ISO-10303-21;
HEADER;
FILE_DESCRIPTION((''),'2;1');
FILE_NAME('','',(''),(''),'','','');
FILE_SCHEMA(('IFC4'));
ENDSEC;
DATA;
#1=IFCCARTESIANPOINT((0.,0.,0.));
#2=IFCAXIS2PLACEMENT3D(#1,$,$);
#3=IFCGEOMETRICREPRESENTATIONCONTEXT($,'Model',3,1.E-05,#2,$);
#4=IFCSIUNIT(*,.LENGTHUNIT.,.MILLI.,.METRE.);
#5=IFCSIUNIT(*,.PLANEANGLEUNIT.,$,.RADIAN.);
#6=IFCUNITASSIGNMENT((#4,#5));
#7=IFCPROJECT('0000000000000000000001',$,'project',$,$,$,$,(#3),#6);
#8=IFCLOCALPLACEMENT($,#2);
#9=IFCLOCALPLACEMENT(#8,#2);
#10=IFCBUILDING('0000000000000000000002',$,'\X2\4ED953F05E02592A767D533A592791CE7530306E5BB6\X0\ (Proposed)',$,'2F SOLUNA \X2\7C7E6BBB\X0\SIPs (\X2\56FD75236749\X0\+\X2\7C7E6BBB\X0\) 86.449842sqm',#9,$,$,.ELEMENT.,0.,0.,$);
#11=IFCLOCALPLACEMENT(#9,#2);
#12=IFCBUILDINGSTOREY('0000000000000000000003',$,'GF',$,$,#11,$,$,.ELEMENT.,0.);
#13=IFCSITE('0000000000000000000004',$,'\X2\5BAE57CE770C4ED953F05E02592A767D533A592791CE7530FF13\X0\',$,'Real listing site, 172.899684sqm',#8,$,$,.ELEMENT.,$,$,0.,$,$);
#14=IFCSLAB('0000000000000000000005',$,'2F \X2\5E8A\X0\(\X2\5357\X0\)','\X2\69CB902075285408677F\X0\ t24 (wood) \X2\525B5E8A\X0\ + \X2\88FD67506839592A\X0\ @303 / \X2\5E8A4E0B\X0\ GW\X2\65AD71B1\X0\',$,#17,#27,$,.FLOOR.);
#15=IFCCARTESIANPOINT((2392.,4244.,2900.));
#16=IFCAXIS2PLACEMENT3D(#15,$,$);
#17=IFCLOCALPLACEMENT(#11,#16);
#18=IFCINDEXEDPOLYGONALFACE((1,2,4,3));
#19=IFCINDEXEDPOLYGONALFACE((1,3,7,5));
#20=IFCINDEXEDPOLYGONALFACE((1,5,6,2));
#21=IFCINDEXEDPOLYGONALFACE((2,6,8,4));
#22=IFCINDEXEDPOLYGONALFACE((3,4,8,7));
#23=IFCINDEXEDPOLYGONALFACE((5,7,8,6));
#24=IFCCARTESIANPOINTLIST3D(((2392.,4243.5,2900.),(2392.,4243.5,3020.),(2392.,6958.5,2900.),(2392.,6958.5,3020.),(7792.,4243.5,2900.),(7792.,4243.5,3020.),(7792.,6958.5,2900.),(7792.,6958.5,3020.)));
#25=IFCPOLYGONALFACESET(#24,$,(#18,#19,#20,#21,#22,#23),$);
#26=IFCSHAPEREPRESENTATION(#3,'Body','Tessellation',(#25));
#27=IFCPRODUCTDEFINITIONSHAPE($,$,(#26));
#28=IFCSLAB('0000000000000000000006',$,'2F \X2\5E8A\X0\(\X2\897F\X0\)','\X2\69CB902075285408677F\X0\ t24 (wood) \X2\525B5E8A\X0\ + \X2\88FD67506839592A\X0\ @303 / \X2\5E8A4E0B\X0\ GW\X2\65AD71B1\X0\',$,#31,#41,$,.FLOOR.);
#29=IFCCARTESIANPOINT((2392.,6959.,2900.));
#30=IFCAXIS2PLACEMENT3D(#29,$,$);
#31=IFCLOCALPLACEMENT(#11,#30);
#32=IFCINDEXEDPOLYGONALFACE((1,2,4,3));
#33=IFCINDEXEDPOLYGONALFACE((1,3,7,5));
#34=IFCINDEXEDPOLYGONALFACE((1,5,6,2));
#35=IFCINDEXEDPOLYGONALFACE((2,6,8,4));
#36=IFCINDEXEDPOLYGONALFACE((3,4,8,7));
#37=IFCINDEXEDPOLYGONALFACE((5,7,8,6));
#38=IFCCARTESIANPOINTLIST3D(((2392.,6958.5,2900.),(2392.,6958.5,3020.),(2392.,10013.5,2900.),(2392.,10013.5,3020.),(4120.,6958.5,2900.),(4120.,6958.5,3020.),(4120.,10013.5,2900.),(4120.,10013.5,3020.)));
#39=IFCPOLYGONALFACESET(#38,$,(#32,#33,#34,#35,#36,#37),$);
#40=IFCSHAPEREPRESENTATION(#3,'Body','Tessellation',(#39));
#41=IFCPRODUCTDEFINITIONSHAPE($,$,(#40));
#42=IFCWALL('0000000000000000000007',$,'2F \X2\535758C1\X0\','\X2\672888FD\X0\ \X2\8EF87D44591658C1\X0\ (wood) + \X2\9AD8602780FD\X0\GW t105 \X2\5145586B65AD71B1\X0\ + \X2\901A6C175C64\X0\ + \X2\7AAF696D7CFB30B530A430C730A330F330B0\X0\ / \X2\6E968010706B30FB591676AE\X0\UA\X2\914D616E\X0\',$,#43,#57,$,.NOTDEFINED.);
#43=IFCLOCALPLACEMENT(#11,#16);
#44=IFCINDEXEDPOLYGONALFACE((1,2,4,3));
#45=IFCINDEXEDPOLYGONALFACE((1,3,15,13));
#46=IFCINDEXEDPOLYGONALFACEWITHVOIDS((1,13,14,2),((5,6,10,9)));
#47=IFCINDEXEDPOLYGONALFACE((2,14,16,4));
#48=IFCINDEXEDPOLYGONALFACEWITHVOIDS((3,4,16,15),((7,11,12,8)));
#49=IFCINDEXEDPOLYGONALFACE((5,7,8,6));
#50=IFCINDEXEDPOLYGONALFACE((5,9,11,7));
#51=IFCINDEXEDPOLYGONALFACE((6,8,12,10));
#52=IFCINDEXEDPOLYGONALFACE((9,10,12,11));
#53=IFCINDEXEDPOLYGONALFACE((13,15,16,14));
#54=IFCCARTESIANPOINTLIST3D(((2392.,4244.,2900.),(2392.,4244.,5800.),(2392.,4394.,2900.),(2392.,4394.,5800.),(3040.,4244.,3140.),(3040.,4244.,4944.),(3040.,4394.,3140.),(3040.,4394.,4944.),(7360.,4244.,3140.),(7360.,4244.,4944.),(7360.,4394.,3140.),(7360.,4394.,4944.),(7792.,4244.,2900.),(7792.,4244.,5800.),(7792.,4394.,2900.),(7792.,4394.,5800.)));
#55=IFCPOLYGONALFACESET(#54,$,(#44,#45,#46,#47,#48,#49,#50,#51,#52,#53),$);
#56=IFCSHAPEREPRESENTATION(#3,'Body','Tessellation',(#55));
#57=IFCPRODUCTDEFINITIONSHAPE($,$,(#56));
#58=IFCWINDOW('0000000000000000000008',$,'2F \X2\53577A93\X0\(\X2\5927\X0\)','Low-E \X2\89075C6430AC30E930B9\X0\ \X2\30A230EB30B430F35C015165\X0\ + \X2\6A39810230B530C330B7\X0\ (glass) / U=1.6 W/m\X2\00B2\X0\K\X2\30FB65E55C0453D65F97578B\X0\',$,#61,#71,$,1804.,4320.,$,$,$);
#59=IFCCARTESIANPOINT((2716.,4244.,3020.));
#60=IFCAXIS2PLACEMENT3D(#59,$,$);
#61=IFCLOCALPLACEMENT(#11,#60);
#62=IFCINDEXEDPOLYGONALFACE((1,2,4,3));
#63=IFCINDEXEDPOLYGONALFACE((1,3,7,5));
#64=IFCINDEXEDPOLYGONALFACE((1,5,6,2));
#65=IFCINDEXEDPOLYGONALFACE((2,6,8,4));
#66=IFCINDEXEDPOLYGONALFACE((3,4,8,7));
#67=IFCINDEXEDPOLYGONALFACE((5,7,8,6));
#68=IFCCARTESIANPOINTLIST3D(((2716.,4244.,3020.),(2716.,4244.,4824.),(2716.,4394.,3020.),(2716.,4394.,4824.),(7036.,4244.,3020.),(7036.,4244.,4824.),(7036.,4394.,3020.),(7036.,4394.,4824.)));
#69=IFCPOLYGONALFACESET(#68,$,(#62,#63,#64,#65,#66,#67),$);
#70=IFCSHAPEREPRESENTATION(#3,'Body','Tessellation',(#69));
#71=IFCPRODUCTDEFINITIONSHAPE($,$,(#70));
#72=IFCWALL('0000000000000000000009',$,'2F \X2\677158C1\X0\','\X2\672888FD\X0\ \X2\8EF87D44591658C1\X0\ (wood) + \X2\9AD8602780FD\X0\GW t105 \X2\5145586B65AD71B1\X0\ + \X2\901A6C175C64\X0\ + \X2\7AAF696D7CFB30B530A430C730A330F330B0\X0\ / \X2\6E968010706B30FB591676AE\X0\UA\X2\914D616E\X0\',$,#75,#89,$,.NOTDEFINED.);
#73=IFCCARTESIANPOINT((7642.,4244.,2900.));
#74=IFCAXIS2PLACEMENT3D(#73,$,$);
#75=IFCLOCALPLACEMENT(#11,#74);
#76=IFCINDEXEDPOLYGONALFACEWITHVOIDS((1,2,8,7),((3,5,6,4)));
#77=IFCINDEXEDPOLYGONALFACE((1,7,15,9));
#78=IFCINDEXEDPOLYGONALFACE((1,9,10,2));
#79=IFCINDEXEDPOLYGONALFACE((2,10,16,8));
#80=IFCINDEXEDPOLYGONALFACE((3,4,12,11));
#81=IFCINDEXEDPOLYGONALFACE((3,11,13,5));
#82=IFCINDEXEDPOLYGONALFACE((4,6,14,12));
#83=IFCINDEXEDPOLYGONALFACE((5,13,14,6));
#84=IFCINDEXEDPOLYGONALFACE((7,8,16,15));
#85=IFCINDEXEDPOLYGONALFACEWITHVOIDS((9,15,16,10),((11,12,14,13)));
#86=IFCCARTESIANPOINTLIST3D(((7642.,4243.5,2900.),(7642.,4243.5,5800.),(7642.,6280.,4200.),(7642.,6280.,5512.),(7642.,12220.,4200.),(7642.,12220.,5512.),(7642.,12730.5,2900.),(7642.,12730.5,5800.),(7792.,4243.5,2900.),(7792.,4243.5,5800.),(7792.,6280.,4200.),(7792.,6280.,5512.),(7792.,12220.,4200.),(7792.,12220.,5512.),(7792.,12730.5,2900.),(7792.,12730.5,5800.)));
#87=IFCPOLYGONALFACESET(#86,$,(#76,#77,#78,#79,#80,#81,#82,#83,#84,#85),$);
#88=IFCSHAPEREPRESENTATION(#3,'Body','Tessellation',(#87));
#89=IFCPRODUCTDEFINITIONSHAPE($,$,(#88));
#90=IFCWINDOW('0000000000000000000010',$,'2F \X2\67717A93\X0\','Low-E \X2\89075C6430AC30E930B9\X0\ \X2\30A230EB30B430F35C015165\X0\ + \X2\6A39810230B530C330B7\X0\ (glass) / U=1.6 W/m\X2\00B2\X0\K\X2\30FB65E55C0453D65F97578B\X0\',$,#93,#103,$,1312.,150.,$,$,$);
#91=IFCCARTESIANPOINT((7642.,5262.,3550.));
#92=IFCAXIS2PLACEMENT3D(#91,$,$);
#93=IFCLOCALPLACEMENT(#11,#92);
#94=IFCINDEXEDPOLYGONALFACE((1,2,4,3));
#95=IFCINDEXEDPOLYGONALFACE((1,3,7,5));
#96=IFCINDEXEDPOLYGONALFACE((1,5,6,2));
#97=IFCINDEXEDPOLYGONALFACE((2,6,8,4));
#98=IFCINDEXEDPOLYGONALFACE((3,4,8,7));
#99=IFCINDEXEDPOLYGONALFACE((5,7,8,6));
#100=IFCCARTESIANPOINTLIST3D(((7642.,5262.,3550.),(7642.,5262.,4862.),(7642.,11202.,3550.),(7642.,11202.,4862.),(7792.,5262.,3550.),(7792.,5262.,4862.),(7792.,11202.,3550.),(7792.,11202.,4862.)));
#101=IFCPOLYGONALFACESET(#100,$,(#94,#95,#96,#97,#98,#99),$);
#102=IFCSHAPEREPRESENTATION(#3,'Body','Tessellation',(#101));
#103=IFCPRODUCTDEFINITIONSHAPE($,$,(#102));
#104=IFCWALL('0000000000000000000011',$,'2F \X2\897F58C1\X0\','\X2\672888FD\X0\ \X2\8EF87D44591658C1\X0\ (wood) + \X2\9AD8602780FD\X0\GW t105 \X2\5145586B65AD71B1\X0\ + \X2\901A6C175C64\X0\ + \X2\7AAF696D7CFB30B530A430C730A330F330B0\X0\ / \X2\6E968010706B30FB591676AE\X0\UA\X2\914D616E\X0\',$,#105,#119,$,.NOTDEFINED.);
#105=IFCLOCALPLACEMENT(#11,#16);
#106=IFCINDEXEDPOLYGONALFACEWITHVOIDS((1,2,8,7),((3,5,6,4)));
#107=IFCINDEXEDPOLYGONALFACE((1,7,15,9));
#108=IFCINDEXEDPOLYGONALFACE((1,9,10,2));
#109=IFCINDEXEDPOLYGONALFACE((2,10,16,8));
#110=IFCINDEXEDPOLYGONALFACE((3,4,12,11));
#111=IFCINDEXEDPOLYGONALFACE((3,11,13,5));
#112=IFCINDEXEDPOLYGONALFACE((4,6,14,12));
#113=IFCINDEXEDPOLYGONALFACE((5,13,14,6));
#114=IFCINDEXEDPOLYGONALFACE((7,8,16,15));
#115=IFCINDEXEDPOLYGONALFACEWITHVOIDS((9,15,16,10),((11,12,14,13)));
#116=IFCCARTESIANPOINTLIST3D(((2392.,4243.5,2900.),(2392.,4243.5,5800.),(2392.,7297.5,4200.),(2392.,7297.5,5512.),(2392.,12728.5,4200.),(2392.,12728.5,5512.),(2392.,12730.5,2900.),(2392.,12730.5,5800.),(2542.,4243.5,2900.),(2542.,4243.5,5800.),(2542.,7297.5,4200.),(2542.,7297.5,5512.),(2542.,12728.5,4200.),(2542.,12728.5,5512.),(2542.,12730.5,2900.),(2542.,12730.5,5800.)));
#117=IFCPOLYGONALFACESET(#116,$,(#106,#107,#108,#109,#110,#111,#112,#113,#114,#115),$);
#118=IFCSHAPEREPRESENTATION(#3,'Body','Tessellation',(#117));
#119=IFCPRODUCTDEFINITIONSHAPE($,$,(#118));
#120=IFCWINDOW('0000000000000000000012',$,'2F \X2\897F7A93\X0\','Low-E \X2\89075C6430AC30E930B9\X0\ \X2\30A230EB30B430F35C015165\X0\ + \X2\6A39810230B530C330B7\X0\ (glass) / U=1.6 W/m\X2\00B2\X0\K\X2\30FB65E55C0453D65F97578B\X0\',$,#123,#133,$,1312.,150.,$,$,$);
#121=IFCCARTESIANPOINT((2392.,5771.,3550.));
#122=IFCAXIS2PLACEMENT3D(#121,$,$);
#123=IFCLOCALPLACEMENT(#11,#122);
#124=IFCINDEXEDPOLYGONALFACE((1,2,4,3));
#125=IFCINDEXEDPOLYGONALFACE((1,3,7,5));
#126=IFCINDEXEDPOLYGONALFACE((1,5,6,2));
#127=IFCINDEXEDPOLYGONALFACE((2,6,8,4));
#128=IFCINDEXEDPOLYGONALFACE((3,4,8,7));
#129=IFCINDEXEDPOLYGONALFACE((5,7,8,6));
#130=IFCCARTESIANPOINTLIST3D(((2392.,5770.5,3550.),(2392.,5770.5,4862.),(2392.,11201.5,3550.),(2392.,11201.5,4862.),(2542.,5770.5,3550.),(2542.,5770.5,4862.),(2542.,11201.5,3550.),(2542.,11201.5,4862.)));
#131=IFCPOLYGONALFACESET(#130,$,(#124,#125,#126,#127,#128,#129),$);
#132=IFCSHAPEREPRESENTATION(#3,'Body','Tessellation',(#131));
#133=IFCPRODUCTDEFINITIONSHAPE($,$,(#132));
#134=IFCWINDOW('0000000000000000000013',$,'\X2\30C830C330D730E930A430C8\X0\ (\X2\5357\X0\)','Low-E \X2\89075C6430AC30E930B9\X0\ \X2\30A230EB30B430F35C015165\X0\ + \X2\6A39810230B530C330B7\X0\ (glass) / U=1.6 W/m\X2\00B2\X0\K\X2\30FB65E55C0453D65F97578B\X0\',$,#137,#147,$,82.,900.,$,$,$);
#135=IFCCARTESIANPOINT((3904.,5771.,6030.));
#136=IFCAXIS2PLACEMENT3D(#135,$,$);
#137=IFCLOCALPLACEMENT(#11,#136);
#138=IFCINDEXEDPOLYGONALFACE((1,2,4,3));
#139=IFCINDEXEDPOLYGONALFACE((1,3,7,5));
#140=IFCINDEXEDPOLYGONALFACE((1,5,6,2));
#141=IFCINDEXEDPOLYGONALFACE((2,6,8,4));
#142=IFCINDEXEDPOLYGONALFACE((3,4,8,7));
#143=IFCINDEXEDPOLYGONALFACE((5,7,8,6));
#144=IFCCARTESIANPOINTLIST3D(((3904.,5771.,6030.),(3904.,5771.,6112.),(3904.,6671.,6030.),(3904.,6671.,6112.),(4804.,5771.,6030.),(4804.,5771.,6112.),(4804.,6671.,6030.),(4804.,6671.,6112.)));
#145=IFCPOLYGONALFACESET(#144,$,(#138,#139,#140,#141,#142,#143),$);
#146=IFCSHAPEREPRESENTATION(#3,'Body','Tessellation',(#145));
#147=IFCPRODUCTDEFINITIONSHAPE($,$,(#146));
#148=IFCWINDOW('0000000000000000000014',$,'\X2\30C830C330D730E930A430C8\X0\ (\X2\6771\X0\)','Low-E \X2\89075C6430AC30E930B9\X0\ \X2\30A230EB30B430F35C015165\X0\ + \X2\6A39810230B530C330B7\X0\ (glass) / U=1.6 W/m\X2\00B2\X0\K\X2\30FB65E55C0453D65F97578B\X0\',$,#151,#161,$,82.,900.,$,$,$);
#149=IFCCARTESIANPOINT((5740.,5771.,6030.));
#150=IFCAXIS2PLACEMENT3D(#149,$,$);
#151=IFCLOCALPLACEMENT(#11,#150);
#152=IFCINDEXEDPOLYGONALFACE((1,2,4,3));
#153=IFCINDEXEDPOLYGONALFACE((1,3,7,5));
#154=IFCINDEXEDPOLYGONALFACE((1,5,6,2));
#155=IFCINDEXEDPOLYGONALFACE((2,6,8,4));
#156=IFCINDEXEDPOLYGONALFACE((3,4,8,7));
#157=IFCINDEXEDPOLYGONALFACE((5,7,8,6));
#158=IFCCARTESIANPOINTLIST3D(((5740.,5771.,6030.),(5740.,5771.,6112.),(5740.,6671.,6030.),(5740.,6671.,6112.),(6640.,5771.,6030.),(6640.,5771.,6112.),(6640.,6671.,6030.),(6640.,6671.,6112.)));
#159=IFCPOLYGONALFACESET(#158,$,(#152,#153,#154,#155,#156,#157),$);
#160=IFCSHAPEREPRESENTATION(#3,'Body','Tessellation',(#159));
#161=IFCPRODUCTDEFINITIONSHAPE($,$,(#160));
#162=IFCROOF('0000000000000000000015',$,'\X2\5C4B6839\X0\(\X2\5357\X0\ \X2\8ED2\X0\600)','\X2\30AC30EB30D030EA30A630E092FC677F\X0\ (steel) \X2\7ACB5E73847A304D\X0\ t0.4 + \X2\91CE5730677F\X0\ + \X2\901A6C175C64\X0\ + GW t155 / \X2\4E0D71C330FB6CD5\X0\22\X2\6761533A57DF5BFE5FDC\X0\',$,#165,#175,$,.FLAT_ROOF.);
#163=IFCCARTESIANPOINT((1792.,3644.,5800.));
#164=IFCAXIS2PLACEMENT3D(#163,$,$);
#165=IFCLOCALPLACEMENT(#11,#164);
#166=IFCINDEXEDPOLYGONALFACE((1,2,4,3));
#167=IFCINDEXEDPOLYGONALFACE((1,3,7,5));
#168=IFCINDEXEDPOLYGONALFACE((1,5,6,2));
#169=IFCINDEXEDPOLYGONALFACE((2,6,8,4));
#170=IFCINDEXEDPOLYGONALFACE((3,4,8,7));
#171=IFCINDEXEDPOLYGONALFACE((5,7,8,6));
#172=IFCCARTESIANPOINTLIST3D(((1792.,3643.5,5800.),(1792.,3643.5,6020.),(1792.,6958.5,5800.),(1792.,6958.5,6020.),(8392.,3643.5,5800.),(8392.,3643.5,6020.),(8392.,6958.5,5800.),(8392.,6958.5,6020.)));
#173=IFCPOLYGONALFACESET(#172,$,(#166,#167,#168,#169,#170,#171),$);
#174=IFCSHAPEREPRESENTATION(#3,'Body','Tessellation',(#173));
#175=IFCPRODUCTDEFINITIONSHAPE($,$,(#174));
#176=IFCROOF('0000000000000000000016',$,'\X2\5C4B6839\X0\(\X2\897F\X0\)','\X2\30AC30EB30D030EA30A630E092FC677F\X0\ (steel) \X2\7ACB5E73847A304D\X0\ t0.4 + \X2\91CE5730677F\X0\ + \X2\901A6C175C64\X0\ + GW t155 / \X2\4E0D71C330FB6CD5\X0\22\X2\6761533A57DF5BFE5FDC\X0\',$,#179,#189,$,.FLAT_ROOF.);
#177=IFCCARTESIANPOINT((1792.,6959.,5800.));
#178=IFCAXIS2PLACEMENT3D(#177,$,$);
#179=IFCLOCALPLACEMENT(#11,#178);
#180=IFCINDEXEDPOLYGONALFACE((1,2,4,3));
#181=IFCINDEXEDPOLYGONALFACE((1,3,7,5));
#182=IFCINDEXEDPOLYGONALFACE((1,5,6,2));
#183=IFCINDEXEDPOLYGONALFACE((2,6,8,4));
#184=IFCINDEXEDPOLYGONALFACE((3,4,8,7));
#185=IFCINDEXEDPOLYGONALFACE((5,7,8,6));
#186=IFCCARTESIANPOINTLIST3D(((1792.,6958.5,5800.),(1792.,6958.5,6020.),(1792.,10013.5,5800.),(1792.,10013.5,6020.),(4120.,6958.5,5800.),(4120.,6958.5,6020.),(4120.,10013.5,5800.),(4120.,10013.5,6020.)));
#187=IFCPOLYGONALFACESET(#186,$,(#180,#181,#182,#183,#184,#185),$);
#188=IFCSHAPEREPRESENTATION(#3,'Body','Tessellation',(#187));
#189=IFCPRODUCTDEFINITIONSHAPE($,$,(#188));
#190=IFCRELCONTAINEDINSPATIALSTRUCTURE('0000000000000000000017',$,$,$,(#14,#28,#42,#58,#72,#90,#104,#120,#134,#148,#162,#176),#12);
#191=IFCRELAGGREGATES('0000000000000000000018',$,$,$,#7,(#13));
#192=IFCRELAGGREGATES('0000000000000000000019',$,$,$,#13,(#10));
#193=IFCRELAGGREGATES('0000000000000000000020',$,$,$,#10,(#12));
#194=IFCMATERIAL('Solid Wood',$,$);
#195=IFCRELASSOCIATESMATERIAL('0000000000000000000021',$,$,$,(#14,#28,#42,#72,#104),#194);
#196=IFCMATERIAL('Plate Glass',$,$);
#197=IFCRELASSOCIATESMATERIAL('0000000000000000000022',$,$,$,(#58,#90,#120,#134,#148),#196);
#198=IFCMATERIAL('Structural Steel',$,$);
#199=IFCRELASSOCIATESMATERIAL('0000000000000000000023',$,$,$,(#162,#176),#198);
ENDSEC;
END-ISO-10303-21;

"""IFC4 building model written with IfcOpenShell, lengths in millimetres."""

from ifc_helpers import new_model, si_unit, frame, frame_2d, origin, place, context, project, spatial, rectangle, extrude, material, element, fill, save


model = new_model("IFC4")

# Units and contexts
model_context = context("Model", 3, precision=1e-05, world=origin())
ifc_project = project(units=[si_unit("LENGTHUNIT", "METRE", prefix="MILLI"), si_unit("PLANEANGLEUNIT", "RADIAN")], contexts=[model_context])

# Site, building, storey
site_placement = place(None, origin())
site = spatial("IfcSite", under=ifc_project, at=site_placement, Name="宮城県仙台市太白区大野田３", ObjectType="Real listing site, 172.899684sqm", CompositionType="ELEMENT", RefElevation=0.0)
building_placement = place(site_placement, origin())
building = spatial("IfcBuilding", under=site, at=building_placement, Name="仙台市太白区大野田の家 (Proposed)", ObjectType="2F SOLUNA 籾殻SIPs (国産杉+籾殻) 86.449842sqm", CompositionType="ELEMENT", ElevationOfRefHeight=0.0, ElevationOfTerrain=0.0)
storey_placement = place(building_placement, origin())
storey = spatial("IfcBuildingStorey", under=building, at=storey_placement, Name="GF", CompositionType="ELEMENT", Elevation=0.0)

# Slabs
ifc_material_1 = material(Name="Solid Wood")
slab_1_placement = place(storey_placement, frame((2392.0, 4244.0, 2900.0)))
element("IfcSlab", 1, at=slab_1_placement, inside=storey, material=ifc_material_1, Name="2F 床(南)", Description="構造用合板 t24 (wood) 剛床 + 製材根太 @303 / 床下 GW断熱", PredefinedType="FLOOR", context=model_context, shape_type="SweptSolid", body=[
    extrude(rectangle(XDim=5400.0, YDim=2715.0, at=frame_2d((2700.0, 1357.0))), frame((2392.0, 4244.0, 2900.0)), (0.0, 0.0, 1.0), 120.0),
])
slab_2_placement = place(storey_placement, frame((2392.0, 6959.0, 2900.0)))
element("IfcSlab", 2, at=slab_2_placement, inside=storey, material=ifc_material_1, Name="2F 床(西)", Description="構造用合板 t24 (wood) 剛床 + 製材根太 @303 / 床下 GW断熱", PredefinedType="FLOOR", context=model_context, shape_type="SweptSolid", body=[
    extrude(rectangle(XDim=1728.0, YDim=3055.0, at=frame_2d((864.0, 1527.0))), frame((2392.0, 6959.0, 2900.0)), (0.0, 0.0, 1.0), 120.0),
])

# Walls, openings, windows
wall_1_placement = place(storey_placement, frame((2392.0, 4244.0, 2900.0)))
wall_1 = element("IfcWall", 3, at=wall_1_placement, inside=storey, material=ifc_material_1, Name="2F 南壁", Description="木製 軸組外壁 (wood) + 高性能GW t105 充填断熱 + 通気層 + 窯業系サイディング / 準耐火・外皮UA配慮", PredefinedType="NOTDEFINED", context=model_context, shape_type="SweptSolid", body=[
    extrude(rectangle(XDim=5400.0, YDim=150.0, at=frame_2d((2700.0, 75.0))), frame((2392.0, 4244.0, 2900.0)), (0.0, 0.0, 1.0), 2900.0),
])
opening_1_placement = place(storey_placement, frame((2716.0, 4244.0, 3020.0)))
opening_1 = element("IfcOpeningElement", 4, at=opening_1_placement, cuts=wall_1, PredefinedType="NOTDEFINED", context=model_context, shape_type="SweptSolid", body=[
    extrude(rectangle(XDim=4320.0, YDim=150.0, at=frame_2d((2160.0, 75.0))), frame((2716.0, 4244.0, 3020.0)), (0.0, 0.0, 1.0), 1804.0),
])
ifc_material_2 = material(Name="Plate Glass")
window_1_placement = place(storey_placement, frame((2716.0, 4244.0, 3020.0)))
window_1 = element("IfcWindow", 5, at=window_1_placement, inside=storey, material=ifc_material_2, Name="2F 南窓(大)", Description="Low-E 複層ガラス アルゴン封入 + 樹脂サッシ (glass) / U=1.6 W/m²K・日射取得型", OverallHeight=1804.0, OverallWidth=4320.0, context=model_context, shape_type="SweptSolid", body=[
    extrude(rectangle(XDim=4320.0, YDim=150.0, at=frame_2d((2160.0, 75.0))), frame((2716.0, 4244.0, 3020.0)), (0.0, 0.0, 1.0), 1804.0),
])
fill(opening_1, window_1)
wall_2_placement = place(storey_placement, frame((7642.0, 4244.0, 2900.0)))
wall_2 = element("IfcWall", 6, at=wall_2_placement, inside=storey, material=ifc_material_1, Name="2F 東壁", Description="木製 軸組外壁 (wood) + 高性能GW t105 充填断熱 + 通気層 + 窯業系サイディング / 準耐火・外皮UA配慮", PredefinedType="NOTDEFINED", context=model_context, shape_type="SweptSolid", body=[
    extrude(rectangle(XDim=150.0, YDim=8487.0, at=frame_2d((75.0, 4243.0))), frame((7642.0, 4244.0, 2900.0)), (0.0, 0.0, 1.0), 2900.0),
])
opening_2_placement = place(storey_placement, frame((7642.0, 5262.0, 3550.0)))
opening_2 = element("IfcOpeningElement", 7, at=opening_2_placement, cuts=wall_2, PredefinedType="NOTDEFINED", context=model_context, shape_type="SweptSolid", body=[
    extrude(rectangle(XDim=150.0, YDim=5940.0, at=frame_2d((75.0, 2970.0))), frame((7642.0, 5262.0, 3550.0)), (0.0, 0.0, 1.0), 1312.0),
])
window_2_placement = place(storey_placement, frame((7642.0, 5262.0, 3550.0)))
window_2 = element("IfcWindow", 8, at=window_2_placement, inside=storey, material=ifc_material_2, Name="2F 東窓", Description="Low-E 複層ガラス アルゴン封入 + 樹脂サッシ (glass) / U=1.6 W/m²K・日射取得型", OverallHeight=1312.0, OverallWidth=150.0, context=model_context, shape_type="SweptSolid", body=[
    extrude(rectangle(XDim=150.0, YDim=5940.0, at=frame_2d((75.0, 2970.0))), frame((7642.0, 5262.0, 3550.0)), (0.0, 0.0, 1.0), 1312.0),
])
fill(opening_2, window_2)
wall_3_placement = place(storey_placement, frame((2392.0, 4244.0, 2900.0)))
wall_3 = element("IfcWall", 9, at=wall_3_placement, inside=storey, material=ifc_material_1, Name="2F 西壁", Description="木製 軸組外壁 (wood) + 高性能GW t105 充填断熱 + 通気層 + 窯業系サイディング / 準耐火・外皮UA配慮", PredefinedType="NOTDEFINED", context=model_context, shape_type="SweptSolid", body=[
    extrude(rectangle(XDim=150.0, YDim=8487.0, at=frame_2d((75.0, 4243.0))), frame((2392.0, 4244.0, 2900.0)), (0.0, 0.0, 1.0), 2900.0),
])
opening_3_placement = place(storey_placement, frame((2392.0, 5771.0, 3550.0)))
opening_3 = element("IfcOpeningElement", 10, at=opening_3_placement, cuts=wall_3, PredefinedType="NOTDEFINED", context=model_context, shape_type="SweptSolid", body=[
    extrude(rectangle(XDim=150.0, YDim=5431.0, at=frame_2d((75.0, 2715.0))), frame((2392.0, 5771.0, 3550.0)), (0.0, 0.0, 1.0), 1312.0),
])
window_3_placement = place(storey_placement, frame((2392.0, 5771.0, 3550.0)))
window_3 = element("IfcWindow", 11, at=window_3_placement, inside=storey, material=ifc_material_2, Name="2F 西窓", Description="Low-E 複層ガラス アルゴン封入 + 樹脂サッシ (glass) / U=1.6 W/m²K・日射取得型", OverallHeight=1312.0, OverallWidth=150.0, context=model_context, shape_type="SweptSolid", body=[
    extrude(rectangle(XDim=150.0, YDim=5431.0, at=frame_2d((75.0, 2715.0))), frame((2392.0, 5771.0, 3550.0)), (0.0, 0.0, 1.0), 1312.0),
])
fill(opening_3, window_3)

# Windows
window_4_placement = place(storey_placement, frame((3904.0, 5771.0, 6030.0)))
element("IfcWindow", 12, at=window_4_placement, inside=storey, material=ifc_material_2, Name="トップライト (南)", Description="Low-E 複層ガラス アルゴン封入 + 樹脂サッシ (glass) / U=1.6 W/m²K・日射取得型", OverallHeight=82.0, OverallWidth=900.0, context=model_context, shape_type="SweptSolid", body=[
    extrude(rectangle(XDim=900.0, YDim=900.0, at=frame_2d((450.0, 450.0))), frame((3904.0, 5771.0, 6030.0)), (0.0, 0.0, 1.0), 82.0),
])
window_5_placement = place(storey_placement, frame((5740.0, 5771.0, 6030.0)))
element("IfcWindow", 13, at=window_5_placement, inside=storey, material=ifc_material_2, Name="トップライト (東)", Description="Low-E 複層ガラス アルゴン封入 + 樹脂サッシ (glass) / U=1.6 W/m²K・日射取得型", OverallHeight=82.0, OverallWidth=900.0, context=model_context, shape_type="SweptSolid", body=[
    extrude(rectangle(XDim=900.0, YDim=900.0, at=frame_2d((450.0, 450.0))), frame((5740.0, 5771.0, 6030.0)), (0.0, 0.0, 1.0), 82.0),
])

# Roofs
ifc_material_3 = material(Name="Structural Steel")
roof_1_placement = place(storey_placement, frame((1792.0, 3644.0, 5800.0)))
element("IfcRoof", 14, at=roof_1_placement, inside=storey, material=ifc_material_3, Name="屋根(南 軒600)", Description="ガルバリウム鋼板 (steel) 立平葺き t0.4 + 野地板 + 通気層 + GW t155 / 不燃・法22条区域対応", PredefinedType="FLAT_ROOF", context=model_context, shape_type="SweptSolid", body=[
    extrude(rectangle(XDim=6600.0, YDim=3315.0, at=frame_2d((3300.0, 1657.0))), frame((1792.0, 3644.0, 5800.0)), (0.0, 0.0, 1.0), 220.0),
])
roof_2_placement = place(storey_placement, frame((1792.0, 6959.0, 5800.0)))
element("IfcRoof", 15, at=roof_2_placement, inside=storey, material=ifc_material_3, Name="屋根(西)", Description="ガルバリウム鋼板 (steel) 立平葺き t0.4 + 野地板 + 通気層 + GW t155 / 不燃・法22条区域対応", PredefinedType="FLAT_ROOF", context=model_context, shape_type="SweptSolid", body=[
    extrude(rectangle(XDim=2328.0, YDim=3055.0, at=frame_2d((1164.0, 1527.0))), frame((1792.0, 6959.0, 5800.0)), (0.0, 0.0, 1.0), 220.0),
])

save(model, "model.ifc")
